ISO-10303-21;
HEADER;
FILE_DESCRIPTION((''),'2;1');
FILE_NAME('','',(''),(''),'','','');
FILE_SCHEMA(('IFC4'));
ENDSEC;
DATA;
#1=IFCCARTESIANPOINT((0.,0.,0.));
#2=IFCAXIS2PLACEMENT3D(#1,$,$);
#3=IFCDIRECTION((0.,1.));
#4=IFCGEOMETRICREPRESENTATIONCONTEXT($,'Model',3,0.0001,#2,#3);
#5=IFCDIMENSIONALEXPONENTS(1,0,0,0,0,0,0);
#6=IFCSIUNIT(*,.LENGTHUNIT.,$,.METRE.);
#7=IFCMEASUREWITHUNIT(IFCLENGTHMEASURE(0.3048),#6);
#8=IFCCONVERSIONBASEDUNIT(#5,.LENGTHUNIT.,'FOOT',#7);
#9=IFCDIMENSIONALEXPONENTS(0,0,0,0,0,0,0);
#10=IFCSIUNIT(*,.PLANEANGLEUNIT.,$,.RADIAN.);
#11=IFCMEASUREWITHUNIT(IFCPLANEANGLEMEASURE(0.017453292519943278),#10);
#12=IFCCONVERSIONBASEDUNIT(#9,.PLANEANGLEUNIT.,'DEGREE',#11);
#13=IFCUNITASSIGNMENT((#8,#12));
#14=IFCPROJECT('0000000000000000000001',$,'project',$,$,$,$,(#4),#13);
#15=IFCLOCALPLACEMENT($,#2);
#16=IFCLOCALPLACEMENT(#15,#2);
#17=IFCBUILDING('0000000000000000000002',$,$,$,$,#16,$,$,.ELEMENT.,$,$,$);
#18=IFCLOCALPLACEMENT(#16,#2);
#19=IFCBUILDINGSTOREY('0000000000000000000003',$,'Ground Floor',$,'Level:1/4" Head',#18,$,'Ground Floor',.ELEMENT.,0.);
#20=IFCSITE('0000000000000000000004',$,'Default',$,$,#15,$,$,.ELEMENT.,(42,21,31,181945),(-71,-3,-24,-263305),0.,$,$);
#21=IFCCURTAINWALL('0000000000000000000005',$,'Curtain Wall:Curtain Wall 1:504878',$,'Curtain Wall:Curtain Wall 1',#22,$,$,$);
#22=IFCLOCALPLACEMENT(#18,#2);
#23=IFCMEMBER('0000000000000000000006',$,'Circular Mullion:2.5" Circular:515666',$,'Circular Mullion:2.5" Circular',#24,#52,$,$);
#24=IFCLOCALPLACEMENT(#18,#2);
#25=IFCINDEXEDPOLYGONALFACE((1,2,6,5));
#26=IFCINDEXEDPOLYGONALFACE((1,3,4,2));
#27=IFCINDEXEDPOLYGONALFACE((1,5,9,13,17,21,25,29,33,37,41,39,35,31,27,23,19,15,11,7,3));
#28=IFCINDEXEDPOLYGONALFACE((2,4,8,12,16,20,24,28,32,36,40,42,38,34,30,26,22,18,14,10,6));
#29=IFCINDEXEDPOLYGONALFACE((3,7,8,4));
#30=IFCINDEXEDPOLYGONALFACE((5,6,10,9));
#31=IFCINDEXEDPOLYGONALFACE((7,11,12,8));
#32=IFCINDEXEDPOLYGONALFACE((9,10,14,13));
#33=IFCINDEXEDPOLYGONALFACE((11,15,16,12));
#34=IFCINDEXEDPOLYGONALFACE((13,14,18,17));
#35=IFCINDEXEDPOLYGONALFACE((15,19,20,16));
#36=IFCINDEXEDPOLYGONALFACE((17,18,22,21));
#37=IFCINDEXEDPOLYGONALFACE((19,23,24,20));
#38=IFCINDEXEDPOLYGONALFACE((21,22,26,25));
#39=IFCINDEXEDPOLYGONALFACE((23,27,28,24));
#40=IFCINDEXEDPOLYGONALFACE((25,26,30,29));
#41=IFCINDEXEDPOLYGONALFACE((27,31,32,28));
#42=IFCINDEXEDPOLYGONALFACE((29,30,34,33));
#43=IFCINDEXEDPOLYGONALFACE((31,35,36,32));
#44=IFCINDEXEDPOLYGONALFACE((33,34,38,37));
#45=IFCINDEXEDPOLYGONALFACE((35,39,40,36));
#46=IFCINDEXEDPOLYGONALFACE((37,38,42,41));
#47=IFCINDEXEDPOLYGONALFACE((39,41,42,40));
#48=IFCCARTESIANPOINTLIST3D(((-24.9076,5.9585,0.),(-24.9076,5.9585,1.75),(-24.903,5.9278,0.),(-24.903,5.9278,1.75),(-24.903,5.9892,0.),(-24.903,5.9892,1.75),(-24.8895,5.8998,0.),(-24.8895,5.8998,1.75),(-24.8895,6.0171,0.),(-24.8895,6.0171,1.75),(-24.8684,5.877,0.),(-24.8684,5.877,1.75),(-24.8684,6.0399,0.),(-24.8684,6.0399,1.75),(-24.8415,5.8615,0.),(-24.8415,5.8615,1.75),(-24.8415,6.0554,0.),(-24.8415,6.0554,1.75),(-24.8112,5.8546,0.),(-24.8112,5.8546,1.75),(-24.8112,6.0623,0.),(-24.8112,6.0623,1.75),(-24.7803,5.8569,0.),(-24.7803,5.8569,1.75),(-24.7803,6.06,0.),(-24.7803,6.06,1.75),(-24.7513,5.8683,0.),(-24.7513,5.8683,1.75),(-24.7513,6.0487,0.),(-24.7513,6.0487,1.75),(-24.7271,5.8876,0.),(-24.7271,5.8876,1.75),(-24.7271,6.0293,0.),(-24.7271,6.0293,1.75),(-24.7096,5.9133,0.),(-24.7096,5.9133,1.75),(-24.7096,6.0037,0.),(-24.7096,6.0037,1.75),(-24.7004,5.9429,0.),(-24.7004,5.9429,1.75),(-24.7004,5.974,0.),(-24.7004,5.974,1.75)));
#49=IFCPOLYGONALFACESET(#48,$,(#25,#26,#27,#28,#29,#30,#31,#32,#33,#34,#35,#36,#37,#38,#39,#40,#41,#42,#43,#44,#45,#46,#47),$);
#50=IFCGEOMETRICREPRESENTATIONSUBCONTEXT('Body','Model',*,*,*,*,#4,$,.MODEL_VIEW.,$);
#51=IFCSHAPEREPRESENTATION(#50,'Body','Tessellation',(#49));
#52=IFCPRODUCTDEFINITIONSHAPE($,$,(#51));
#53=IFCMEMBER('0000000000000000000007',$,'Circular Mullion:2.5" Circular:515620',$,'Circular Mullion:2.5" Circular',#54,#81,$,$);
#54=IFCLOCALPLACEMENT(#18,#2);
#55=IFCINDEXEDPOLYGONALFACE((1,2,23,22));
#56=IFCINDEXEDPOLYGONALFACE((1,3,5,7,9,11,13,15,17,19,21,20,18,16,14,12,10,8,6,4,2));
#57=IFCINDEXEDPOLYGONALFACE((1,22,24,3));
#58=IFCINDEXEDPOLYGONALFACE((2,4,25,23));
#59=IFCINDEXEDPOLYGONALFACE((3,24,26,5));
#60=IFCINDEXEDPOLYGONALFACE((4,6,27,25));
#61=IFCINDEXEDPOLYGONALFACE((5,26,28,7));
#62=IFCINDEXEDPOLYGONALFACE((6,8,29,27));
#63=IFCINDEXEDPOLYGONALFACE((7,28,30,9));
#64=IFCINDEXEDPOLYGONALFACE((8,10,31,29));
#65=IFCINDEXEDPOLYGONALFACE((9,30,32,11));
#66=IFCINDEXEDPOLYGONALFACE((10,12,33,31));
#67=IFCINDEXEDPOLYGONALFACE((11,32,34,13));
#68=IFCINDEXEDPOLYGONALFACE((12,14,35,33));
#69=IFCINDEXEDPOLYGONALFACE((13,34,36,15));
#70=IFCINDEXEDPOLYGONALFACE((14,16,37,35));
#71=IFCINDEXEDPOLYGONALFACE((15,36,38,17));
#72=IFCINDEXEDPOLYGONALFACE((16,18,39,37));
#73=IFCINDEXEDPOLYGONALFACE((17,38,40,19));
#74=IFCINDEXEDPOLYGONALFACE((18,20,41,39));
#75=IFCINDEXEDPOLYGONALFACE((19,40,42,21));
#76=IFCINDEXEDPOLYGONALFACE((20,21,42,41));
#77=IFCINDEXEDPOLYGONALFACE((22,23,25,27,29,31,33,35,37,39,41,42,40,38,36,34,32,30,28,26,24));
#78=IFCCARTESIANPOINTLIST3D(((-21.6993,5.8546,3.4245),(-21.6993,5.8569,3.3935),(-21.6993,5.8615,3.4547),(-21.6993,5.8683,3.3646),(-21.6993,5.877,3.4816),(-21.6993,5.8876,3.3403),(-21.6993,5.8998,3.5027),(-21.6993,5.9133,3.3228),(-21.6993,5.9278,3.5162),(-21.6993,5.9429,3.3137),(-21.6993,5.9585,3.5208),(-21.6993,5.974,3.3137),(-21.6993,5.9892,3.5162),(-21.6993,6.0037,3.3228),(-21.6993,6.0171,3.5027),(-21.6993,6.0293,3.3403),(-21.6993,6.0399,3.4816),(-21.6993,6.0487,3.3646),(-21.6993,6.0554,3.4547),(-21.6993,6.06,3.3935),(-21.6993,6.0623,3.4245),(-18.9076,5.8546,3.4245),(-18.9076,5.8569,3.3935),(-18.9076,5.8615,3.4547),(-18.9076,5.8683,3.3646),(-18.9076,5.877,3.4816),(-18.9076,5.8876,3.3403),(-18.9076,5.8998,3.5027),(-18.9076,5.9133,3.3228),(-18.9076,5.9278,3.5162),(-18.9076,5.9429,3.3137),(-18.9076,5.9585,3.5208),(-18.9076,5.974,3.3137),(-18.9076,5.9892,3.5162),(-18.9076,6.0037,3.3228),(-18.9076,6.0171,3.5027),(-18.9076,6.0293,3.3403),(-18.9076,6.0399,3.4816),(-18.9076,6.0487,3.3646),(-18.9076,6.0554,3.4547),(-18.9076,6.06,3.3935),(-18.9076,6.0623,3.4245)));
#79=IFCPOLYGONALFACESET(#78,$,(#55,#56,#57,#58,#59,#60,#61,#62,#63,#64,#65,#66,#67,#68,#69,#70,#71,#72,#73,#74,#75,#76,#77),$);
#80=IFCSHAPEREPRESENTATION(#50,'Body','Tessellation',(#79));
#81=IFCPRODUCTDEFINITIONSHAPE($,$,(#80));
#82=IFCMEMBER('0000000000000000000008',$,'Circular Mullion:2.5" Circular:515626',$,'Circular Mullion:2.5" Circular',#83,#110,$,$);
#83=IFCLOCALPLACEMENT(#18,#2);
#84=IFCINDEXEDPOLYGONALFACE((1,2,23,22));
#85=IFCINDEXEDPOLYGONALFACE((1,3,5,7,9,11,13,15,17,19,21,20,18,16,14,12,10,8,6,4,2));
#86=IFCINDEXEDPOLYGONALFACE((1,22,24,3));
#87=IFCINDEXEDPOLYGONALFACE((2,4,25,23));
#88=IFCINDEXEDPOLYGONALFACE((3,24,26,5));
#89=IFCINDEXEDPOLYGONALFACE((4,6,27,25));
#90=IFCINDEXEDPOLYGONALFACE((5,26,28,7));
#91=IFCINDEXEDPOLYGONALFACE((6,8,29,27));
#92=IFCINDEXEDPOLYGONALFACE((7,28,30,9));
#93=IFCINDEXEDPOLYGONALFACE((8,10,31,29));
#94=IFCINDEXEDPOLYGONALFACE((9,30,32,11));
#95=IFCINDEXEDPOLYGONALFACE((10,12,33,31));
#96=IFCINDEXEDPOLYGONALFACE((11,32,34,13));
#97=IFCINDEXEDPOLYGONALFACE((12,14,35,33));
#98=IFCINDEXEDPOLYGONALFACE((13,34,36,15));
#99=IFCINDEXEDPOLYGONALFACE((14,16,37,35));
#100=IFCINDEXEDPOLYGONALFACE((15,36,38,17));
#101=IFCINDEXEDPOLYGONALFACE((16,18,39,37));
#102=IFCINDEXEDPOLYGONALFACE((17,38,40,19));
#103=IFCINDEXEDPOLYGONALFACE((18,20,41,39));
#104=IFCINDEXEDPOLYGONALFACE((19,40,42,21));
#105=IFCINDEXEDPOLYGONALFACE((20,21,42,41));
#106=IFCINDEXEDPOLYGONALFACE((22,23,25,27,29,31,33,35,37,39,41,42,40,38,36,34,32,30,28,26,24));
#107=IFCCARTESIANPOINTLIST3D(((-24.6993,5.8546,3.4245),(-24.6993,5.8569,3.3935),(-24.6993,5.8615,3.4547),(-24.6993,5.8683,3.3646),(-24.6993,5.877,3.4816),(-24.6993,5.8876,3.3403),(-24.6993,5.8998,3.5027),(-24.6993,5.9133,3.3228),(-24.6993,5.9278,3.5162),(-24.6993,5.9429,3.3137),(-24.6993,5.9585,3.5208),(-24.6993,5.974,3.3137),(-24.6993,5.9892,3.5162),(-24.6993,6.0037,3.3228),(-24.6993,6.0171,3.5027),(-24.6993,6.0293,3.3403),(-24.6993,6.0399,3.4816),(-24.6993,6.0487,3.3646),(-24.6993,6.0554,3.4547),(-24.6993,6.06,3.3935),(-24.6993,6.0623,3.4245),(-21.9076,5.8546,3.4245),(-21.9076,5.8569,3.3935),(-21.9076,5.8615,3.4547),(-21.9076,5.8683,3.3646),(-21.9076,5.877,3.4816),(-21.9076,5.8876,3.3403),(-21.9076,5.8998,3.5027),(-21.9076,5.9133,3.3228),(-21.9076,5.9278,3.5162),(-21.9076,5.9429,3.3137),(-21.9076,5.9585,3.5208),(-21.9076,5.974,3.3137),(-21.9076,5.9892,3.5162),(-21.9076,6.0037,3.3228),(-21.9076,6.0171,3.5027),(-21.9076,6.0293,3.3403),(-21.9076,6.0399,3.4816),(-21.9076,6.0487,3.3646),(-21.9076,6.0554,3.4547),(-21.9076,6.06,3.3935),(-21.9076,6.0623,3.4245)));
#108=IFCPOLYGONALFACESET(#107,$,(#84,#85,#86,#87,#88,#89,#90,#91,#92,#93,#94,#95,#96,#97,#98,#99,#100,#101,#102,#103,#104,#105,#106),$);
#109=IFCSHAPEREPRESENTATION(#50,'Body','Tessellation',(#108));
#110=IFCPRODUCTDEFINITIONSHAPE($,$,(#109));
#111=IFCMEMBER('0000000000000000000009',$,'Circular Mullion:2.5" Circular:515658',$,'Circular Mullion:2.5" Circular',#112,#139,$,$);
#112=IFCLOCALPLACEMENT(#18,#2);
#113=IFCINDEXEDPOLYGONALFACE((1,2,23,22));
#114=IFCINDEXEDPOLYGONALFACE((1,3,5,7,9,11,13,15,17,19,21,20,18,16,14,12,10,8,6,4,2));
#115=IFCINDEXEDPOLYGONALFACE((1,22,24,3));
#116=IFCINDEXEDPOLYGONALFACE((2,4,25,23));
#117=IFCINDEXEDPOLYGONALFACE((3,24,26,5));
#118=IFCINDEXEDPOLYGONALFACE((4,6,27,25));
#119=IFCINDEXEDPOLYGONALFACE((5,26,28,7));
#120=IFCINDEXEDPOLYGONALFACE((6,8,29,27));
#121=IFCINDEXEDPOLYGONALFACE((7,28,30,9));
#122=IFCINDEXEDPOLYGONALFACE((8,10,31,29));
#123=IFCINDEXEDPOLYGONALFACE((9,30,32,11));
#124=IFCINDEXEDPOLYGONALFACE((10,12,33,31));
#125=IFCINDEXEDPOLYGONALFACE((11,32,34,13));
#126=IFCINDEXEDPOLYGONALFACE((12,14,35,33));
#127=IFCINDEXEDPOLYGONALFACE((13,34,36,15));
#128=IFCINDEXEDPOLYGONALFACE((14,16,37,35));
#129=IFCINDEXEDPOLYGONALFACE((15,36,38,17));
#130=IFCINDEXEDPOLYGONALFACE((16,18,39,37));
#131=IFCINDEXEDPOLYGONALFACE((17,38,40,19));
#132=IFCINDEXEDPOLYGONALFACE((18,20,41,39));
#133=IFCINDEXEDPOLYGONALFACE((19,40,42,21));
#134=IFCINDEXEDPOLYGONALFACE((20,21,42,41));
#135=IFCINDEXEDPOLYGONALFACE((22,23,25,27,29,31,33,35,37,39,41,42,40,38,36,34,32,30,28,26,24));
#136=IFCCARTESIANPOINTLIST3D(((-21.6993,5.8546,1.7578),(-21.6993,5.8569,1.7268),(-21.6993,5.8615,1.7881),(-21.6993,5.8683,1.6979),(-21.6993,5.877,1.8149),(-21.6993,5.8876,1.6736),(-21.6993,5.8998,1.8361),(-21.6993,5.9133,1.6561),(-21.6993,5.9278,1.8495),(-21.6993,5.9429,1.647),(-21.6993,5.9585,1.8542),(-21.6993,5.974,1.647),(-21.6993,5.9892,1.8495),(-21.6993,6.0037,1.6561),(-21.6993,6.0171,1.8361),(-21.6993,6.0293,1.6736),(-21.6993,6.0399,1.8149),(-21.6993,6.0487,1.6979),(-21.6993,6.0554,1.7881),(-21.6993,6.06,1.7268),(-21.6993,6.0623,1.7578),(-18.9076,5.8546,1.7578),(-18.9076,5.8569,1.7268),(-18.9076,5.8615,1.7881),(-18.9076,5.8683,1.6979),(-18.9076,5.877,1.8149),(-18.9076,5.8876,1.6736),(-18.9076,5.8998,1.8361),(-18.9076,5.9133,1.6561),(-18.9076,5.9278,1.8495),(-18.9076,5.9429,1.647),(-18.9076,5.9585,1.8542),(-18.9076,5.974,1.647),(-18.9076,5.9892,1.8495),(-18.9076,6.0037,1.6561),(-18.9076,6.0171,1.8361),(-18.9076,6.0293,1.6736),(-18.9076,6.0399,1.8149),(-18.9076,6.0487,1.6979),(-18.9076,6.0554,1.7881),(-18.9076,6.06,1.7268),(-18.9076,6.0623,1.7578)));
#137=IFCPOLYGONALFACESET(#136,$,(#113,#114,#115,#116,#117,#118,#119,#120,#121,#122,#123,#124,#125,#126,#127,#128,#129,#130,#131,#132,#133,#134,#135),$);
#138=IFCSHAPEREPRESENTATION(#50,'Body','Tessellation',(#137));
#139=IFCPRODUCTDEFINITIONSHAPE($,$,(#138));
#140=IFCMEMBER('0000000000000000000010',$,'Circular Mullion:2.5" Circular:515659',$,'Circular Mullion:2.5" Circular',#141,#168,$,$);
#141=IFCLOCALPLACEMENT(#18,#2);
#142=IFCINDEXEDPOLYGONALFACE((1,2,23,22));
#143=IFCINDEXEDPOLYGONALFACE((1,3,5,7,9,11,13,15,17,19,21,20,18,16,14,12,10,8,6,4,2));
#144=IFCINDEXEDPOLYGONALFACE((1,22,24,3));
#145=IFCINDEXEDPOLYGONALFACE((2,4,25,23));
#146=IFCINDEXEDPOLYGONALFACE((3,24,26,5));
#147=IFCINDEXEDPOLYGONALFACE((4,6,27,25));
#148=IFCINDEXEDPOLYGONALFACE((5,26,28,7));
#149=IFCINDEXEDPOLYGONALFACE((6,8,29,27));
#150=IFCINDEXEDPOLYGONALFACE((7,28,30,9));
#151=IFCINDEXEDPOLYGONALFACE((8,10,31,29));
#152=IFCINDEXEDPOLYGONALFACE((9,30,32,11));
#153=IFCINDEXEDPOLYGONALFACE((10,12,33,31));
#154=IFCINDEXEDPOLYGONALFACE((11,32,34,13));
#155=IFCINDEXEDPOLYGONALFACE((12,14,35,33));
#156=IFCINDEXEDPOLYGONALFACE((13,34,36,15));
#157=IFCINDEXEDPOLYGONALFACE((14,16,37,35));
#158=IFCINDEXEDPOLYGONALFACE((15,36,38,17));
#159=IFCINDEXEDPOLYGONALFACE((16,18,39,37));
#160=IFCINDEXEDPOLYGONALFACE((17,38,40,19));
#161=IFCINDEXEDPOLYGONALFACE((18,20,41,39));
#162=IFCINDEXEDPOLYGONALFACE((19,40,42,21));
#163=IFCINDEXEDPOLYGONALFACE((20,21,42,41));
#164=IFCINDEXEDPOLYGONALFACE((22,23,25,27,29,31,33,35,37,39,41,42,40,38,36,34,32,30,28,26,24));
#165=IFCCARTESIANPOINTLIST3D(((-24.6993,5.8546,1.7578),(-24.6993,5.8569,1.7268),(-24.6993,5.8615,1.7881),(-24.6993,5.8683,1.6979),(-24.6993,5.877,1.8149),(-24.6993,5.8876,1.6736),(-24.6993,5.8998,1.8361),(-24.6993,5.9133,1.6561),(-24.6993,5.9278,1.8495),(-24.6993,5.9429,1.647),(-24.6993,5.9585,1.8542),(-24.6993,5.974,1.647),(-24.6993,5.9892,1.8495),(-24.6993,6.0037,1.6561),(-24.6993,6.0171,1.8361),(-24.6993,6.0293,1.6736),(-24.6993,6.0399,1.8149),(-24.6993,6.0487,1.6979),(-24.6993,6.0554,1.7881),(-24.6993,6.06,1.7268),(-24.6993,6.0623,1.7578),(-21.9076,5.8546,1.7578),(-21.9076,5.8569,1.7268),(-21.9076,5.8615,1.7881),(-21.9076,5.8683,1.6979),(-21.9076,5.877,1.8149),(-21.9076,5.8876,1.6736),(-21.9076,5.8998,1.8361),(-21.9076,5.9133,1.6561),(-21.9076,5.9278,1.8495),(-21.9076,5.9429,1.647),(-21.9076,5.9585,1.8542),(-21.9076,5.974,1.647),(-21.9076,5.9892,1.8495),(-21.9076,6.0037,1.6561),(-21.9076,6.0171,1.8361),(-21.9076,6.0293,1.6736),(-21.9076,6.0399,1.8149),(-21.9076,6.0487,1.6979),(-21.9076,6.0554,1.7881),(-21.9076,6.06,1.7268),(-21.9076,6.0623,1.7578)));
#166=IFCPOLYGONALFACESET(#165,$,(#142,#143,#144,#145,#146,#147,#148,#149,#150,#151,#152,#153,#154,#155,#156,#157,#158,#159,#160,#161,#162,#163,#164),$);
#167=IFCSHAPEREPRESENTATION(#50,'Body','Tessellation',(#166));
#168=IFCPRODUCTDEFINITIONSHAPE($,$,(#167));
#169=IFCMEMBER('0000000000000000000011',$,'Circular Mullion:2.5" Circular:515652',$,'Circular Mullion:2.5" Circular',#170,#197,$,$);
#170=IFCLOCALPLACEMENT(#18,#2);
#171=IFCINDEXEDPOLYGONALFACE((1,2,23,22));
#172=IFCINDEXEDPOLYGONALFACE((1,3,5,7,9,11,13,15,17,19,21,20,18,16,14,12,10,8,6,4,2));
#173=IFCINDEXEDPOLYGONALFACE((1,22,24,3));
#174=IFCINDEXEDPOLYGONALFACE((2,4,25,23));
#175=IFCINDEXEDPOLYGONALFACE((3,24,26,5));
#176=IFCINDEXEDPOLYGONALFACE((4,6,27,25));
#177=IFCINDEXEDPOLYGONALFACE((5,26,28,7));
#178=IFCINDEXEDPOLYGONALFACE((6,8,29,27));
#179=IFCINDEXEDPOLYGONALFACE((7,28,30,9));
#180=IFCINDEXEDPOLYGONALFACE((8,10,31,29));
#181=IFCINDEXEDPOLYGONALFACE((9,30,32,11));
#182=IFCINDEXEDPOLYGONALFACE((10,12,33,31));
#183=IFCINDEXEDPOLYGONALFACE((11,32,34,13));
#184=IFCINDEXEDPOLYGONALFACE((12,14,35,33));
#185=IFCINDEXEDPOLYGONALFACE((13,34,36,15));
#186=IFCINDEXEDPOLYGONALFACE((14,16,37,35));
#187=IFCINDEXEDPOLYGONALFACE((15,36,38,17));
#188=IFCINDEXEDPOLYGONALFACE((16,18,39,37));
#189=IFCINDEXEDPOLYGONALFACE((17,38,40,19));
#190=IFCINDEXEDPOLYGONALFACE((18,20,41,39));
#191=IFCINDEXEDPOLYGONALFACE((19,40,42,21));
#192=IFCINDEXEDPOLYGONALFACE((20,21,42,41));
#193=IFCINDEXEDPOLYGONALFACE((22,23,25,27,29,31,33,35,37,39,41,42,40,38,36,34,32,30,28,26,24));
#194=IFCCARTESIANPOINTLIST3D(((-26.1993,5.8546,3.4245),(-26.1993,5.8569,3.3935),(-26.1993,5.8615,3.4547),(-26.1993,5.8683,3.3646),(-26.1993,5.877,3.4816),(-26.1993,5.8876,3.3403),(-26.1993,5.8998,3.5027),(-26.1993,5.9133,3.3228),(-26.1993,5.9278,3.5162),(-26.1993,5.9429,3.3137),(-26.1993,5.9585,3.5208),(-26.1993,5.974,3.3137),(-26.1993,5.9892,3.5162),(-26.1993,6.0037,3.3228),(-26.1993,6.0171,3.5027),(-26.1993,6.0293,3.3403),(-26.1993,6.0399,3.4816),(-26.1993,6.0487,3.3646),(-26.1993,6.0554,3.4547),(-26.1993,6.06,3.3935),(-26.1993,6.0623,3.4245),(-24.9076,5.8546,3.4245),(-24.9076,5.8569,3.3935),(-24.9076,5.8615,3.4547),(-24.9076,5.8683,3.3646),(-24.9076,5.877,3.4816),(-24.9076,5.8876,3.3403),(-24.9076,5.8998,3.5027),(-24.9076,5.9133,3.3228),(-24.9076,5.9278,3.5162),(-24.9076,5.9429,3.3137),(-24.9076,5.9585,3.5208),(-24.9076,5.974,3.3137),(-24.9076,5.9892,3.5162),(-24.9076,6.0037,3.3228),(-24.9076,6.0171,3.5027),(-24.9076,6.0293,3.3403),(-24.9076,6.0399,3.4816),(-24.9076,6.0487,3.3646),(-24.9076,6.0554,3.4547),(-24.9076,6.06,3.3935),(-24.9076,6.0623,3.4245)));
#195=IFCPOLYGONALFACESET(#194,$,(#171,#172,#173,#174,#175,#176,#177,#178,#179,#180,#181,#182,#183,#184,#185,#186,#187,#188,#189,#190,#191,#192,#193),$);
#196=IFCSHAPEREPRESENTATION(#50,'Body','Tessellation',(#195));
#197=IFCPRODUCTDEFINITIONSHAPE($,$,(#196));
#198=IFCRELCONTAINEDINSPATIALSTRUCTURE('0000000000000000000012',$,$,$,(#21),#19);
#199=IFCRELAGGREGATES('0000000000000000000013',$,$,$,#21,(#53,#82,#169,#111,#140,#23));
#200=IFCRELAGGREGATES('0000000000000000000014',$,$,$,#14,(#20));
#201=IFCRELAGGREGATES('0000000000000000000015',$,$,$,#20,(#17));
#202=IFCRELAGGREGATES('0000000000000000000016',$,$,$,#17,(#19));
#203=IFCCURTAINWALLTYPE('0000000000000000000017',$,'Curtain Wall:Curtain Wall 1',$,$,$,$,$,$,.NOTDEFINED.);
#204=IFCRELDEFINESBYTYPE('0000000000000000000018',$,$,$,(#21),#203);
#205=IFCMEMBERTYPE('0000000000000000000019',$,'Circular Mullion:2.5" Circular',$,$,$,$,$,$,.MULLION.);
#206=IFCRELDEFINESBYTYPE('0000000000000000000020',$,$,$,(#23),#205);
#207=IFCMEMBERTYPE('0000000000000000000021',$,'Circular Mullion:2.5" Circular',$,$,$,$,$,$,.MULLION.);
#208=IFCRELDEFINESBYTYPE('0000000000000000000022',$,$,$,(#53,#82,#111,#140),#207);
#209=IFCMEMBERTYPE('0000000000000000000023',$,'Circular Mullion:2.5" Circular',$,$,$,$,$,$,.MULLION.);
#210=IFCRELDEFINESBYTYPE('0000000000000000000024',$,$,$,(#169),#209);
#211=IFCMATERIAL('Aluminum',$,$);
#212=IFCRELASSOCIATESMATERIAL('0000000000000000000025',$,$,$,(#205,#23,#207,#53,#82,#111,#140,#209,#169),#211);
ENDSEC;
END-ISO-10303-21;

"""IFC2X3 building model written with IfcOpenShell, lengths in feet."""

from ifc_helpers import new_model, entity, si_unit, converted_unit, direction, frame, frame_2d, origin, place, context, subcontext, project, spatial, circle, extrude, source, transform, mapped, material, type_object, type_shapes, element, aggregate, save


model = new_model("IFC2X3")

# Units and contexts
model_context = context("Model", 3, precision=0.0001, world=origin(), true_north=direction((0.0, 1.0)))
body_context = subcontext(model_context, "Body", "Model", "MODEL_VIEW")
ifc_project = project(units=[converted_unit("LENGTHUNIT", "FOOT", entity("IfcLengthMeasure", 0.3048), si_unit("LENGTHUNIT", "METRE"), dimensions=[1, 0, 0, 0, 0, 0, 0]), converted_unit("PLANEANGLEUNIT", "DEGREE", entity("IfcPlaneAngleMeasure", 0.017453292519943278), si_unit("PLANEANGLEUNIT", "RADIAN"), dimensions=[0, 0, 0, 0, 0, 0, 0])], contexts=[model_context])

# Site, building, storey
site_placement = place(None, origin())
site = spatial("IfcSite", under=ifc_project, at=site_placement, Name="Default", CompositionType="ELEMENT", RefLatitude=(42, 21, 31, 181945), RefLongitude=(-71, -3, -24, -263305), RefElevation=0.0)
building_placement = place(site_placement, origin())
building = spatial("IfcBuilding", under=site, at=building_placement, CompositionType="ELEMENT")
storey_placement = place(building_placement, origin())
storey = spatial("IfcBuildingStorey", under=building, at=storey_placement, Name="Ground Floor", ObjectType="Level:1/4\" Head", LongName="Ground Floor", CompositionType="ELEMENT", Elevation=0.0)

# Curtain wall, members
curtain_wall_type = type_object("IfcCurtainWallType", Name="Curtain Wall:Curtain Wall 1", PredefinedType="NOTDEFINED")
curtain_wall_placement = place(storey_placement, origin())
curtain_wall = element("IfcCurtainWall", 1, at=curtain_wall_placement, inside=storey, type_object=curtain_wall_type, Name="Curtain Wall:Curtain Wall 1:504878", ObjectType="Curtain Wall:Curtain Wall 1")
ifc_material_1 = material(Name="Aluminum")
member_type_1 = type_object("IfcMemberType", Name="Circular Mullion:2.5\" Circular", PredefinedType="MULLION", material=ifc_material_1)
shared_shape_1 = source(origin(), body_context, "Body", "SweptSolid", [
    extrude(circle(Radius=0.1042, at=frame_2d((0.0, 0.0), x_axis=(1.0, 0.0))), frame((0.0, 0.0, -1.75)), (0.0, 0.0, 1.0), 1.75),
])
type_shapes(member_type_1, [shared_shape_1])
member_1_placement = place(curtain_wall_placement, frame((-24.8034, 5.9585, 0.0), z_axis=(0.0, 0.0, -1.0), x_axis=(-1.0, 0.0, 0.0)))
member_1 = element("IfcMember", 2, at=member_1_placement, type_object=member_type_1, material=ifc_material_1, Name="Circular Mullion:2.5\" Circular:515666", ObjectType="Circular Mullion:2.5\" Circular", context=body_context, shape_type="MappedRepresentation", body=[
    mapped(shared_shape_1, transform((0.0, 0.0, 0.0), scale=1.0)),
])
member_type_2 = type_object("IfcMemberType", Name="Circular Mullion:2.5\" Circular", PredefinedType="MULLION", material=ifc_material_1)
shared_shape_2 = source(origin(), body_context, "Body", "SweptSolid", [
    extrude(circle(Radius=0.1042, at=frame_2d((0.0, 0.0), x_axis=(1.0, 0.0))), frame((0.0, 0.0, -2.7917)), (0.0, 0.0, 1.0), 2.7917),
])
type_shapes(member_type_2, [shared_shape_2])
member_2_placement = place(curtain_wall_placement, frame((-21.6993, 5.9585, 3.4167), z_axis=(-1.0, 0.0, 0.0), x_axis=(0.0, 0.0, 1.0)))
member_2 = element("IfcMember", 3, at=member_2_placement, type_object=member_type_2, material=ifc_material_1, Name="Circular Mullion:2.5\" Circular:515620", ObjectType="Circular Mullion:2.5\" Circular", context=body_context, shape_type="MappedRepresentation", body=[
    mapped(shared_shape_2, transform((0.0, 0.0, 0.0), scale=1.0)),
])
member_3_placement = place(curtain_wall_placement, frame((-24.6993, 5.9585, 3.4167), z_axis=(-1.0, 0.0, 0.0), x_axis=(0.0, 0.0, 1.0)))
member_3 = element("IfcMember", 4, at=member_3_placement, type_object=member_type_2, material=ifc_material_1, Name="Circular Mullion:2.5\" Circular:515626", ObjectType="Circular Mullion:2.5\" Circular", context=body_context, shape_type="MappedRepresentation", body=[
    mapped(shared_shape_2, transform((0.0, 0.0, 0.0), scale=1.0)),
])
member_4_placement = place(curtain_wall_placement, frame((-21.6993, 5.9585, 1.75), z_axis=(-1.0, 0.0, 0.0), x_axis=(0.0, 0.0, 1.0)))
member_4 = element("IfcMember", 5, at=member_4_placement, type_object=member_type_2, material=ifc_material_1, Name="Circular Mullion:2.5\" Circular:515658", ObjectType="Circular Mullion:2.5\" Circular", context=body_context, shape_type="MappedRepresentation", body=[
    mapped(shared_shape_2, transform((0.0, 0.0, 0.0), scale=1.0)),
])
member_5_placement = place(curtain_wall_placement, frame((-24.6993, 5.9585, 1.75), z_axis=(-1.0, 0.0, 0.0), x_axis=(0.0, 0.0, 1.0)))
member_5 = element("IfcMember", 6, at=member_5_placement, type_object=member_type_2, material=ifc_material_1, Name="Circular Mullion:2.5\" Circular:515659", ObjectType="Circular Mullion:2.5\" Circular", context=body_context, shape_type="MappedRepresentation", body=[
    mapped(shared_shape_2, transform((0.0, 0.0, 0.0), scale=1.0)),
])
member_type_3 = type_object("IfcMemberType", Name="Circular Mullion:2.5\" Circular", PredefinedType="MULLION", material=ifc_material_1)
shared_shape_3 = source(origin(), body_context, "Body", "SweptSolid", [
    extrude(circle(Radius=0.1042, at=frame_2d((0.0, 0.0), x_axis=(1.0, 0.0))), frame((0.0, 0.0, -1.2917)), (0.0, 0.0, 1.0), 1.2917),
])
type_shapes(member_type_3, [shared_shape_3])
member_6_placement = place(curtain_wall_placement, frame((-26.1993, 5.9585, 3.4167), z_axis=(-1.0, 0.0, 0.0), x_axis=(0.0, 0.0, 1.0)))
member_6 = element("IfcMember", 7, at=member_6_placement, type_object=member_type_3, material=ifc_material_1, Name="Circular Mullion:2.5\" Circular:515652", ObjectType="Circular Mullion:2.5\" Circular", context=body_context, shape_type="MappedRepresentation", body=[
    mapped(shared_shape_3, transform((0.0, 0.0, 0.0), scale=1.0)),
])
aggregate(curtain_wall, [member_2, member_3, member_6, member_4, member_5, member_1])

save(model, "model.ifc")
